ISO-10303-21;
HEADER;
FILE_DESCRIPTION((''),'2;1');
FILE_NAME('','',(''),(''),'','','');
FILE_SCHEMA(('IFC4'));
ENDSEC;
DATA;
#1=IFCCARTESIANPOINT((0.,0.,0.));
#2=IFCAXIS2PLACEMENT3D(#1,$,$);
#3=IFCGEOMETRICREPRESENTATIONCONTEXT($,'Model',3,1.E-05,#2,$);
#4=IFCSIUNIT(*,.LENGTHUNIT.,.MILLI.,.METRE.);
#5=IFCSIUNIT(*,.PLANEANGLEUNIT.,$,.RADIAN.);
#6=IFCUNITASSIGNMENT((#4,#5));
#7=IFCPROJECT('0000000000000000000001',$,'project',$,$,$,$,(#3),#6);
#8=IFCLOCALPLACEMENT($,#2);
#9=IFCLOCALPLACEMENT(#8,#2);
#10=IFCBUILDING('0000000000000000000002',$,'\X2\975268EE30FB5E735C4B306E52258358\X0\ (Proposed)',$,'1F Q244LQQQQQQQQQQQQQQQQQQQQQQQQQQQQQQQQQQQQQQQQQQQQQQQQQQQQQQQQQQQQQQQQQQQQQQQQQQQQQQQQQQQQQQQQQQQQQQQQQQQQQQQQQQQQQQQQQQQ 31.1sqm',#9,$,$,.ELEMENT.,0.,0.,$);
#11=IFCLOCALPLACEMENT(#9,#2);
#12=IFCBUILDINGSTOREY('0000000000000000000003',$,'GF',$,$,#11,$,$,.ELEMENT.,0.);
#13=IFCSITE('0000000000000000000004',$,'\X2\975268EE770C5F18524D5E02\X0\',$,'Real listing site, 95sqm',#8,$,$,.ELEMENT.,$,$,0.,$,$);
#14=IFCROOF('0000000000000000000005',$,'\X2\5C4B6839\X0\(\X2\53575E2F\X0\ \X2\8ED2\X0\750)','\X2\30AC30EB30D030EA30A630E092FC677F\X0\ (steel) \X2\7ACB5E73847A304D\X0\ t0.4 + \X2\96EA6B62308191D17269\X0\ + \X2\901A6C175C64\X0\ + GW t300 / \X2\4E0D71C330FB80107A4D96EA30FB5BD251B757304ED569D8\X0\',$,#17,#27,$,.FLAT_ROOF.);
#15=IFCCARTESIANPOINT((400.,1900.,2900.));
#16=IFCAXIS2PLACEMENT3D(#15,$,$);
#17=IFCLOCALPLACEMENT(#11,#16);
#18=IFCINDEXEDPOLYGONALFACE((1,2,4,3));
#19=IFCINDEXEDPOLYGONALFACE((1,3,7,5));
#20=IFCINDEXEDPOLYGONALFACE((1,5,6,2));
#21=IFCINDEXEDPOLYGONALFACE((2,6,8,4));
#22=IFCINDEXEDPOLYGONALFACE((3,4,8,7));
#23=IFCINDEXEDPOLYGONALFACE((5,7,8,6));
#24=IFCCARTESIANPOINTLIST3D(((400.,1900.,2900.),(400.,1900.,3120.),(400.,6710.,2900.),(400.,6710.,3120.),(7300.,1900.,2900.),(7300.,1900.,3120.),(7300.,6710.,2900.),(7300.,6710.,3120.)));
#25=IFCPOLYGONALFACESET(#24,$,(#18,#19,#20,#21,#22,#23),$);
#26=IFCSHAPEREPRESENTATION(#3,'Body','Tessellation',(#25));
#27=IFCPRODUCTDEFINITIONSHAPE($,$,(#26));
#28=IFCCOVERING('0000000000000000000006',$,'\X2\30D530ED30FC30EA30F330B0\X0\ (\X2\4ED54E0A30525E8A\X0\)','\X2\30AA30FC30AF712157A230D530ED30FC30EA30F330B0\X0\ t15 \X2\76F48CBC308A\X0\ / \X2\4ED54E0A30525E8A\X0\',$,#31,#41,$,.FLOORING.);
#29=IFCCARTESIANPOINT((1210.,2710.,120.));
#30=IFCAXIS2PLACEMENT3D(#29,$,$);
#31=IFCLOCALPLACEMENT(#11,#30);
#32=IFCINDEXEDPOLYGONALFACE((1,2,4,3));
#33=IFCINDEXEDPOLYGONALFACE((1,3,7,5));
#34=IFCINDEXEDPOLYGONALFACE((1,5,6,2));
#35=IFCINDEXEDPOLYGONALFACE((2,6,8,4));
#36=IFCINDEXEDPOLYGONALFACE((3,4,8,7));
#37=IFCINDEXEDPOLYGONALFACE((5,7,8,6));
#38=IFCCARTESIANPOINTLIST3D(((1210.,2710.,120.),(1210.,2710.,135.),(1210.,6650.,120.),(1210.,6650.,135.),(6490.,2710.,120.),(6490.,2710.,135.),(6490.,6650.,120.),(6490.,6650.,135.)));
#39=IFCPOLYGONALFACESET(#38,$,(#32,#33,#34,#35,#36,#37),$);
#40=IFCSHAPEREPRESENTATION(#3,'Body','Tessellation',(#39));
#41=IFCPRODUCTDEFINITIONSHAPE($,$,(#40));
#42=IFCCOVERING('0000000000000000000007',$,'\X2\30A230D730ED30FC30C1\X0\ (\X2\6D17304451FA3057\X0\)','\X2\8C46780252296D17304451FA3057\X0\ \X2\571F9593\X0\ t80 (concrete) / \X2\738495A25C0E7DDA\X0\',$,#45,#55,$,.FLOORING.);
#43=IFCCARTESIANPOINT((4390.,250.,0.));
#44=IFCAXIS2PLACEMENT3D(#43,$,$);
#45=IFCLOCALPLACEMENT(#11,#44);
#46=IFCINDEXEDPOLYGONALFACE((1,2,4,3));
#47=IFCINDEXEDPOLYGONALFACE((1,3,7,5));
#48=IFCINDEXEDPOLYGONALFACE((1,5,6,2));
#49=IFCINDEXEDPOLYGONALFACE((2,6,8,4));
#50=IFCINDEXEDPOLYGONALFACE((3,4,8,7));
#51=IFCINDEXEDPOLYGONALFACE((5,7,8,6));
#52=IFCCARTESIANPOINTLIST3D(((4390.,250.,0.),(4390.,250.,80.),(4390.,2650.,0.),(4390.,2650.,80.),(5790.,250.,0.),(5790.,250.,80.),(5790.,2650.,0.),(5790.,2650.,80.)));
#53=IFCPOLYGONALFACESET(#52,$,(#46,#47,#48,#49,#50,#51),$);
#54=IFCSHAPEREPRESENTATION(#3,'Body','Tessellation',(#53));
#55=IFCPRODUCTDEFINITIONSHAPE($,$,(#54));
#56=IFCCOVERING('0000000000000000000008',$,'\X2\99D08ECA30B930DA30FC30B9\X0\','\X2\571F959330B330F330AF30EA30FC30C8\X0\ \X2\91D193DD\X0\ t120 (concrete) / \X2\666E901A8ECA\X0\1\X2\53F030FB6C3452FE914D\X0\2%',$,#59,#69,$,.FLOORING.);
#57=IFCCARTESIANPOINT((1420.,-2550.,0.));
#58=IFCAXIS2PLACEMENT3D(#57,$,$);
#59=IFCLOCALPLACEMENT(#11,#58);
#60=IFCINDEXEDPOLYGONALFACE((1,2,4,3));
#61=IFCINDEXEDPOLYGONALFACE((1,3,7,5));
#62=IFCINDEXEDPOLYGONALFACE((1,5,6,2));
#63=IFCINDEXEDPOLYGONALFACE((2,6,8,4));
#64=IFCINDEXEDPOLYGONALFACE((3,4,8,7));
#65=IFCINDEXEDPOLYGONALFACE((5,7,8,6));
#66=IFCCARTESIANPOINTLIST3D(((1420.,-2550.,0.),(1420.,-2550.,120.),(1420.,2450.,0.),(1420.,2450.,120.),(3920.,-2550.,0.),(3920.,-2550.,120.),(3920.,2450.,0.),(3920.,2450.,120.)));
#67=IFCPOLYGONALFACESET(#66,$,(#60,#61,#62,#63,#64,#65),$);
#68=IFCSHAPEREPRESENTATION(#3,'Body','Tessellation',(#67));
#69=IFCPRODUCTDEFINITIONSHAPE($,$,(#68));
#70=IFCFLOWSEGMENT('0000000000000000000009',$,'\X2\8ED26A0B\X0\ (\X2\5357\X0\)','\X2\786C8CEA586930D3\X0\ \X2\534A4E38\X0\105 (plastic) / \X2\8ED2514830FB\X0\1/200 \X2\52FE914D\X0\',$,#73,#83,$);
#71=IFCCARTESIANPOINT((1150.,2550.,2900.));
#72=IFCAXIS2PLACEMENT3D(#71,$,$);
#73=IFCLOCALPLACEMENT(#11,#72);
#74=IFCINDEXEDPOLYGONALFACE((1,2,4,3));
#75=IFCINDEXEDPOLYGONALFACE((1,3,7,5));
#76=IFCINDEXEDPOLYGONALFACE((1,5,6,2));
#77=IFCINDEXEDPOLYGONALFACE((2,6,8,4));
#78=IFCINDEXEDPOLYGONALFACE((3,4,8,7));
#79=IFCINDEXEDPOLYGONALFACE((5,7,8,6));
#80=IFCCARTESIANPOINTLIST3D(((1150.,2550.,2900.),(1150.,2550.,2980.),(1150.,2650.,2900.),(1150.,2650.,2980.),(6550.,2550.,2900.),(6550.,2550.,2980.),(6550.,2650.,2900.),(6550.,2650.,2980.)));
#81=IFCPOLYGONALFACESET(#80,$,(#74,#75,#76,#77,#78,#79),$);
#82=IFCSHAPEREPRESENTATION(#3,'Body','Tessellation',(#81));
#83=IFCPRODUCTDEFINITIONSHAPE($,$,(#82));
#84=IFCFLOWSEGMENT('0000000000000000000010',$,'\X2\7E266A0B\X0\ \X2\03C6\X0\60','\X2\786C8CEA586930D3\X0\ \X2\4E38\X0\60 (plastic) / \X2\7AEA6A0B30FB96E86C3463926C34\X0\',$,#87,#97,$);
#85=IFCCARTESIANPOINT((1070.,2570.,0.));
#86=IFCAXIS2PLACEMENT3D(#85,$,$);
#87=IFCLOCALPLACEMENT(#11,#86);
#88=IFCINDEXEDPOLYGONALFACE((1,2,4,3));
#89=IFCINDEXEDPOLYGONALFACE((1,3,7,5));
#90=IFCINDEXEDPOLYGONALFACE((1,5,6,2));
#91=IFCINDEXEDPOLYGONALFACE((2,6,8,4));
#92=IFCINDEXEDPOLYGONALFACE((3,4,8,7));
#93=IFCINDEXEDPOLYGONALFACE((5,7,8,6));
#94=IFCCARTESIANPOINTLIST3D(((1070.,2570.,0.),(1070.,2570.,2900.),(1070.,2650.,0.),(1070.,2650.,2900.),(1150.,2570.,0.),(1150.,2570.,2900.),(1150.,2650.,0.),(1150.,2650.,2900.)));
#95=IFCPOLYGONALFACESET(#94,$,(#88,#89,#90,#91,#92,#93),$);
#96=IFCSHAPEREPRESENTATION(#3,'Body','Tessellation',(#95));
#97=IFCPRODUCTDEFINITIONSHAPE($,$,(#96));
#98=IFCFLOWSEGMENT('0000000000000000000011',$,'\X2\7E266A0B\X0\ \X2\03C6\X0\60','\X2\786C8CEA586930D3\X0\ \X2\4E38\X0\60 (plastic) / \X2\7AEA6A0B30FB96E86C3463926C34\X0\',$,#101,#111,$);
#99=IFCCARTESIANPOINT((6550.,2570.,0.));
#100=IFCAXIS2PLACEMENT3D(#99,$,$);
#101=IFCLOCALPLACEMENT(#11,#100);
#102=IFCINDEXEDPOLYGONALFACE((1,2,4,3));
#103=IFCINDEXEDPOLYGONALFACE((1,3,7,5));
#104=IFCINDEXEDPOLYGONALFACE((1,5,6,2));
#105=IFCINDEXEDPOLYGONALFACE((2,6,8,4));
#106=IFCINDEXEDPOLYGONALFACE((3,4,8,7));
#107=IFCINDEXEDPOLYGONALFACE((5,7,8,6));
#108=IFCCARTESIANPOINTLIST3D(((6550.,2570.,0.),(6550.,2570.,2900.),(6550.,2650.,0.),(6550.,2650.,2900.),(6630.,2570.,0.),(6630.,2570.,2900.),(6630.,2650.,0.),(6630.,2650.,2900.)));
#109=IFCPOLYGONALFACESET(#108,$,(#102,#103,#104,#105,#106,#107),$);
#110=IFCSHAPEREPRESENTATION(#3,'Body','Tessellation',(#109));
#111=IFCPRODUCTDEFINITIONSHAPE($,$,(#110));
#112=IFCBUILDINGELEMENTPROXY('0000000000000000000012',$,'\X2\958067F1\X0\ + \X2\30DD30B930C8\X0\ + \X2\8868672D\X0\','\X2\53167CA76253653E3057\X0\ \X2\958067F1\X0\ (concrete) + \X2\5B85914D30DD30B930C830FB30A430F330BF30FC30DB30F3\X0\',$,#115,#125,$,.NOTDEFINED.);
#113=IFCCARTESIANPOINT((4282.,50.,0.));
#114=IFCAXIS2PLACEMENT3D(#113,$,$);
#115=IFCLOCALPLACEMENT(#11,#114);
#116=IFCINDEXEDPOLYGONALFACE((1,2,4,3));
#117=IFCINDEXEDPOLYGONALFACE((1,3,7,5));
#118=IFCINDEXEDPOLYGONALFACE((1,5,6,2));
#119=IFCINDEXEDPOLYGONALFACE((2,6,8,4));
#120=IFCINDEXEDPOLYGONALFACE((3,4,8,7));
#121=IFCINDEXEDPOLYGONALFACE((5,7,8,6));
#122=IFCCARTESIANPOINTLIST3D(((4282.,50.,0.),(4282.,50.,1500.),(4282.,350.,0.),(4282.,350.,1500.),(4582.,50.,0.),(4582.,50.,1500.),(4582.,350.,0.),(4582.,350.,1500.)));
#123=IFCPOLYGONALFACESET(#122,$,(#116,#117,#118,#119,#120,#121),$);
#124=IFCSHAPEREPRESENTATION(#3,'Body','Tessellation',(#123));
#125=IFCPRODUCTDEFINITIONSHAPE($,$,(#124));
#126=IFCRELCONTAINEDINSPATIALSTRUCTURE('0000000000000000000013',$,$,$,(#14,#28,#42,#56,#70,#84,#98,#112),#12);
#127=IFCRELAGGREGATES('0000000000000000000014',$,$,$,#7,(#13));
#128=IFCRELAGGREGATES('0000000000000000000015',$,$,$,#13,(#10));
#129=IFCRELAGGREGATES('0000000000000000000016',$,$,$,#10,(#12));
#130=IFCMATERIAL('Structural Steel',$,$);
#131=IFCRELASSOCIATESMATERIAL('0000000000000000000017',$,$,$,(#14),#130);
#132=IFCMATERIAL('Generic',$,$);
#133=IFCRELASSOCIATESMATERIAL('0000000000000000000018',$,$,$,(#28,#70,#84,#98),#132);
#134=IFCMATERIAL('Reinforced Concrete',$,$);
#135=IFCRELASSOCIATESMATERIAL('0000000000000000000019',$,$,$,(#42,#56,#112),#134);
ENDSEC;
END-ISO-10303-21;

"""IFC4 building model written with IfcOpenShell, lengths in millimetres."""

from ifc_helpers import new_model, si_unit, frame, frame_2d, origin, place, context, project, spatial, rectangle, extrude, material, element, save


model = new_model("IFC4")

# Units and contexts
model_context = context("Model", 3, precision=1e-05, world=origin())
ifc_project = project(units=[si_unit("LENGTHUNIT", "METRE", prefix="MILLI"), si_unit("PLANEANGLEUNIT", "RADIAN")], contexts=[model_context])

# Site, building, storey
site_placement = place(None, origin())
site = spatial("IfcSite", under=ifc_project, at=site_placement, Name="青森県弘前市", ObjectType="Real listing site, 95sqm", CompositionType="ELEMENT", RefElevation=0.0)
building_placement = place(site_placement, origin())
building = spatial("IfcBuilding", under=site, at=building_placement, Name="青森・平屋の別荘 (Proposed)", ObjectType="1F Q244LQQQQQQQQQQQQQQQQQQQQQQQQQQQQQQQQQQQQQQQQQQQQQQQQQQQQQQQQQQQQQQQQQQQQQQQQQQQQQQQQQQQQQQQQQQQQQQQQQQQQQQQQQQQQQQQQQQQ 31.1sqm", CompositionType="ELEMENT", ElevationOfRefHeight=0.0, ElevationOfTerrain=0.0)
storey_placement = place(building_placement, origin())
storey = spatial("IfcBuildingStorey", under=building, at=storey_placement, Name="GF", CompositionType="ELEMENT", Elevation=0.0)

# Shared definitions
ifc_material_1 = material(Name="Reinforced Concrete")

# Roof
ifc_material_2 = material(Name="Structural Steel")
roof_placement = place(storey_placement, frame((400.0, 1900.0, 2900.0)))
element("IfcRoof", 1, at=roof_placement, inside=storey, material=ifc_material_2, Name="屋根(南帯 軒750)", Description="ガルバリウム鋼板 (steel) 立平葺き t0.4 + 雪止め金物 + 通気層 + GW t300 / 不燃・耐積雪・寒冷地仕様", PredefinedType="FLAT_ROOF", context=model_context, shape_type="SweptSolid", body=[
    extrude(rectangle(XDim=6900.0, YDim=4810.0, at=frame_2d((3450.0, 2405.0))), frame((400.0, 1900.0, 2900.0)), (0.0, 0.0, 1.0), 220.0),
])

# Coverings
ifc_material_3 = material(Name="Generic")
covering_1_placement = place(storey_placement, frame((1210.0, 2710.0, 120.0)))
element("IfcCovering", 2, at=covering_1_placement, inside=storey, material=ifc_material_3, Name="フローリング (仕上げ床)", Description="オーク無垢フローリング t15 直貼り / 仕上げ床", PredefinedType="FLOORING", context=model_context, shape_type="SweptSolid", body=[
    extrude(rectangle(XDim=5280.0, YDim=3940.0, at=frame_2d((2640.0, 1970.0))), frame((1210.0, 2710.0, 120.0)), (0.0, 0.0, 1.0), 15.0),
])
covering_2_placement = place(storey_placement, frame((4390.0, 250.0, 0.0)))
element("IfcCovering", 3, at=covering_2_placement, inside=storey, material=ifc_material_1, Name="アプローチ (洗い出し)", Description="豆砂利洗い出し 土間 t80 (concrete) / 玄関導線", PredefinedType="FLOORING", context=model_context, shape_type="SweptSolid", body=[
    extrude(rectangle(XDim=1400.0, YDim=2400.0, at=frame_2d((700.0, 1200.0))), frame((4390.0, 250.0, 0.0)), (0.0, 0.0, 1.0), 80.0),
])
covering_3_placement = place(storey_placement, frame((1420.0, -2550.0, 0.0)))
element("IfcCovering", 4, at=covering_3_placement, inside=storey, material=ifc_material_1, Name="駐車スペース", Description="土間コンクリート 金鏝 t120 (concrete) / 普通車1台・水勾配2%", PredefinedType="FLOORING", context=model_context, shape_type="SweptSolid", body=[
    extrude(rectangle(XDim=2500.0, YDim=5000.0, at=frame_2d((1250.0, 2500.0))), frame((1420.0, -2550.0, 0.0)), (0.0, 0.0, 1.0), 120.0),
])

# Flow segments
flow_segment_1_placement = place(storey_placement, frame((1150.0, 2550.0, 2900.0)))
element("IfcFlowSegment", 5, at=flow_segment_1_placement, inside=storey, material=ifc_material_3, Name="軒樋 (南)", Description="硬質塩ビ 半丸105 (plastic) / 軒先・1/200 勾配", context=model_context, shape_type="SweptSolid", body=[
    extrude(rectangle(XDim=5400.0, YDim=100.0, at=frame_2d((2700.0, 50.0))), frame((1150.0, 2550.0, 2900.0)), (0.0, 0.0, 1.0), 80.0),
])
flow_segment_2_placement = place(storey_placement, frame((1070.0, 2570.0, 0.0)))
element("IfcFlowSegment", 6, at=flow_segment_2_placement, inside=storey, material=ifc_material_3, Name="縦樋 φ60", Description="硬質塩ビ 丸60 (plastic) / 竪樋・雨水排水", context=model_context, shape_type="SweptSolid", body=[
    extrude(rectangle(XDim=80.0, YDim=80.0, at=frame_2d((40.0, 40.0))), frame((1070.0, 2570.0, 0.0)), (0.0, 0.0, 1.0), 2900.0),
])
flow_segment_3_placement = place(storey_placement, frame((6550.0, 2570.0, 0.0)))
element("IfcFlowSegment", 7, at=flow_segment_3_placement, inside=storey, material=ifc_material_3, Name="縦樋 φ60", Description="硬質塩ビ 丸60 (plastic) / 竪樋・雨水排水", context=model_context, shape_type="SweptSolid", body=[
    extrude(rectangle(XDim=80.0, YDim=80.0, at=frame_2d((40.0, 40.0))), frame((6550.0, 2570.0, 0.0)), (0.0, 0.0, 1.0), 2900.0),
])

# Building element proxy
proxy_placement = place(storey_placement, frame((4282.0, 50.0, 0.0)))
element("IfcBuildingElementProxy", 8, at=proxy_placement, inside=storey, material=ifc_material_1, Name="門柱 + ポスト + 表札", Description="化粧打放し 門柱 (concrete) + 宅配ポスト・インターホン", PredefinedType="NOTDEFINED", context=model_context, shape_type="SweptSolid", body=[
    extrude(rectangle(XDim=300.0, YDim=300.0, at=frame_2d((150.0, 150.0))), frame((4282.0, 50.0, 0.0)), (0.0, 0.0, 1.0), 1500.0),
])

save(model, "model.ifc")
